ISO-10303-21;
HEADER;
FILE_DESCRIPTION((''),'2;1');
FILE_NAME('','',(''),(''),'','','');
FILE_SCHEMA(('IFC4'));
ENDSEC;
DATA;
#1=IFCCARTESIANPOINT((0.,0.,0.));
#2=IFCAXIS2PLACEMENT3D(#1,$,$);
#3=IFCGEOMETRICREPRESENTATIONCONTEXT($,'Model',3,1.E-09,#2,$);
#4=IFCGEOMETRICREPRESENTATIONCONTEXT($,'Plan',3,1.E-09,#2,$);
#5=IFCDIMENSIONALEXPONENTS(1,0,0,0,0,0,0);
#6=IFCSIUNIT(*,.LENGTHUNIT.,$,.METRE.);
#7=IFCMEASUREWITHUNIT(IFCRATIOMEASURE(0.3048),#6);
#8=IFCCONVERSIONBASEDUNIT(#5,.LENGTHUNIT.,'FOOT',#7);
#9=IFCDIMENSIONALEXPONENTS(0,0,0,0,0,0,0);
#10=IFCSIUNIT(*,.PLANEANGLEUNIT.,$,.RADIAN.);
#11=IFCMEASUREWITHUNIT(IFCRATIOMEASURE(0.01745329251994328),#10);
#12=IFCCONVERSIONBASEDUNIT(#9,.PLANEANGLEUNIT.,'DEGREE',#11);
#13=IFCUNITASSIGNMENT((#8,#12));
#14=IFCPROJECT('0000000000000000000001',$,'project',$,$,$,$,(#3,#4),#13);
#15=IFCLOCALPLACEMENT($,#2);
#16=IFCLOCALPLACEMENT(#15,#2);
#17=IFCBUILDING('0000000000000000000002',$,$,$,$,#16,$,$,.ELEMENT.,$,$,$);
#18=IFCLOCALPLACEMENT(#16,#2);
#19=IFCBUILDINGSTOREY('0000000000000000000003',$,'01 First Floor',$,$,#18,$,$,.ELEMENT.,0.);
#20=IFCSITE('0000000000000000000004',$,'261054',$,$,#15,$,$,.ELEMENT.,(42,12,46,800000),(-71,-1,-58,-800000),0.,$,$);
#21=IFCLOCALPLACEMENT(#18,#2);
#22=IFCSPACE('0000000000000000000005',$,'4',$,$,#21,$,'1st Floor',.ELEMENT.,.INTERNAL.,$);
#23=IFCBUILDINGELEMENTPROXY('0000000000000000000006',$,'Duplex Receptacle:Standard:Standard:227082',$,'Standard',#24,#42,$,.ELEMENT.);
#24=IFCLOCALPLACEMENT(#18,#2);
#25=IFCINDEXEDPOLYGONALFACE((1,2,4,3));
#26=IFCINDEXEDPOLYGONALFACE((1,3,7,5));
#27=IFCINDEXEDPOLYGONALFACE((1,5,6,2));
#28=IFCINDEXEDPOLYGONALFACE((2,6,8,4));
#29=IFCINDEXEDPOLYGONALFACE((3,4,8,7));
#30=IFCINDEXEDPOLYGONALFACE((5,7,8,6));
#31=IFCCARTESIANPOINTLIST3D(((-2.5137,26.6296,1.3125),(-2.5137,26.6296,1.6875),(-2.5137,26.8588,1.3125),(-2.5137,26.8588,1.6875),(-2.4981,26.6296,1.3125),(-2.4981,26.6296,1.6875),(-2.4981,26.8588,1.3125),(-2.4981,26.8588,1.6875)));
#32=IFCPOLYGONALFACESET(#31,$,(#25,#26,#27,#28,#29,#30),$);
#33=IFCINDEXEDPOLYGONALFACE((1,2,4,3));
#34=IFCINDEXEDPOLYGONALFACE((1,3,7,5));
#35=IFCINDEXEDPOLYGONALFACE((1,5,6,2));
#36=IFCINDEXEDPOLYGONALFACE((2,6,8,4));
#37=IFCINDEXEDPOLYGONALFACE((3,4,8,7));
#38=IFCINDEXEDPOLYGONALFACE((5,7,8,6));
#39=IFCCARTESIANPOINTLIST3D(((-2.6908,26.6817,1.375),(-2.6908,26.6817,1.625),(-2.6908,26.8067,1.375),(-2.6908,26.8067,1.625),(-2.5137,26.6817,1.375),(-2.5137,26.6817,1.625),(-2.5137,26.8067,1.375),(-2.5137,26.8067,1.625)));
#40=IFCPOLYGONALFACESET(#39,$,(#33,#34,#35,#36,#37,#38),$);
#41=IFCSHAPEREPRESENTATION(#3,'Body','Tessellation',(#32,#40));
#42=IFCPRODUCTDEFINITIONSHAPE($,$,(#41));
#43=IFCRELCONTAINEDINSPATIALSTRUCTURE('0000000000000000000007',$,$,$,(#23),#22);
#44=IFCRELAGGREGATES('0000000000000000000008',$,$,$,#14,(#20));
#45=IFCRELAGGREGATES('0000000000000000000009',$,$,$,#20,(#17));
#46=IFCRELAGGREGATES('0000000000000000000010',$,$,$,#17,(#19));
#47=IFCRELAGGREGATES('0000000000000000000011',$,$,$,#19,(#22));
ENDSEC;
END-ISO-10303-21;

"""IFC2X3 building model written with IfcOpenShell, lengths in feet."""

from ifc_helpers import new_model, entity, si_unit, converted_unit, frame, origin, origin_2d_with_axis, place, context, project, spatial, rectangle, extrude, source, transform, mapped, element, save


model = new_model("IFC2X3")

# Units and contexts
model_context = context("Model", 3, precision=1e-09, world=origin())
plan_context = context("Plan", 3, precision=1e-09, world=origin())
ifc_project = project(units=[converted_unit("LENGTHUNIT", "FOOT", entity("IfcRatioMeasure", 0.3048), si_unit("LENGTHUNIT", "METRE"), dimensions=[1, 0, 0, 0, 0, 0, 0]), converted_unit("PLANEANGLEUNIT", "DEGREE", entity("IfcRatioMeasure", 0.01745329251994328), si_unit("PLANEANGLEUNIT", "RADIAN"), dimensions=[0, 0, 0, 0, 0, 0, 0])], contexts=[model_context, plan_context])

# Site, building, storey
site_placement = place(None, origin())
site = spatial("IfcSite", under=ifc_project, at=site_placement, Name="261054", CompositionType="ELEMENT", RefLatitude=(42, 12, 46, 800000), RefLongitude=(-71, -1, -58, -800000), RefElevation=0.0)
building_placement = place(site_placement, origin())
building = spatial("IfcBuilding", under=site, at=building_placement, CompositionType="ELEMENT")
storey_placement = place(building_placement, origin())
storey = spatial("IfcBuildingStorey", under=building, at=storey_placement, Name="01 First Floor", CompositionType="ELEMENT", Elevation=0.0)

# Shared definitions
space_1_placement = place(storey_placement, origin())
space_1 = spatial("IfcSpace", under=storey, at=space_1_placement, Name="4", LongName="1st Floor", CompositionType="ELEMENT", InteriorOrExteriorSpace="INTERNAL")

# Building element proxy
shared_shape_1 = source(origin(), model_context, "Body", "SweptSolid", [
    extrude(rectangle(XDim=0.2292, YDim=0.375, at=origin_2d_with_axis()), frame((0.0, 0.0, 0.0), z_axis=(0.0, 0.0, 1.0), x_axis=(-1.0, 0.0, 0.0)), (0.0, 0.0, 1.0), 0.0156),
    extrude(rectangle(XDim=0.125, YDim=0.25, at=origin_2d_with_axis()), frame((0.0, 0.0, -0.1771), z_axis=(0.0, 0.0, 1.0), x_axis=(-1.0, 0.0, 0.0)), (0.0, 0.0, 1.0), 0.1771),
])
for number, where, z_axis, x_axis, name in (
    (1, (-2.5137, 26.7442, 1.5), (1.0, 0.0, 0.0), (0.0, 1.0, 0.0), "Duplex Receptacle:Standard:Standard:227082"),
):
    element("IfcBuildingElementProxy", number, at=place(space_1_placement, frame(where, z_axis=z_axis, x_axis=x_axis)), inside=space_1, Name=name, ObjectType="Standard", CompositionType="ELEMENT", context=model_context, shape_type="MappedRepresentation", body=[
        mapped(shared_shape_1, transform((0.0, 0.0, 0.0), scale=1.0)),
    ])

save(model, "model.ifc")
